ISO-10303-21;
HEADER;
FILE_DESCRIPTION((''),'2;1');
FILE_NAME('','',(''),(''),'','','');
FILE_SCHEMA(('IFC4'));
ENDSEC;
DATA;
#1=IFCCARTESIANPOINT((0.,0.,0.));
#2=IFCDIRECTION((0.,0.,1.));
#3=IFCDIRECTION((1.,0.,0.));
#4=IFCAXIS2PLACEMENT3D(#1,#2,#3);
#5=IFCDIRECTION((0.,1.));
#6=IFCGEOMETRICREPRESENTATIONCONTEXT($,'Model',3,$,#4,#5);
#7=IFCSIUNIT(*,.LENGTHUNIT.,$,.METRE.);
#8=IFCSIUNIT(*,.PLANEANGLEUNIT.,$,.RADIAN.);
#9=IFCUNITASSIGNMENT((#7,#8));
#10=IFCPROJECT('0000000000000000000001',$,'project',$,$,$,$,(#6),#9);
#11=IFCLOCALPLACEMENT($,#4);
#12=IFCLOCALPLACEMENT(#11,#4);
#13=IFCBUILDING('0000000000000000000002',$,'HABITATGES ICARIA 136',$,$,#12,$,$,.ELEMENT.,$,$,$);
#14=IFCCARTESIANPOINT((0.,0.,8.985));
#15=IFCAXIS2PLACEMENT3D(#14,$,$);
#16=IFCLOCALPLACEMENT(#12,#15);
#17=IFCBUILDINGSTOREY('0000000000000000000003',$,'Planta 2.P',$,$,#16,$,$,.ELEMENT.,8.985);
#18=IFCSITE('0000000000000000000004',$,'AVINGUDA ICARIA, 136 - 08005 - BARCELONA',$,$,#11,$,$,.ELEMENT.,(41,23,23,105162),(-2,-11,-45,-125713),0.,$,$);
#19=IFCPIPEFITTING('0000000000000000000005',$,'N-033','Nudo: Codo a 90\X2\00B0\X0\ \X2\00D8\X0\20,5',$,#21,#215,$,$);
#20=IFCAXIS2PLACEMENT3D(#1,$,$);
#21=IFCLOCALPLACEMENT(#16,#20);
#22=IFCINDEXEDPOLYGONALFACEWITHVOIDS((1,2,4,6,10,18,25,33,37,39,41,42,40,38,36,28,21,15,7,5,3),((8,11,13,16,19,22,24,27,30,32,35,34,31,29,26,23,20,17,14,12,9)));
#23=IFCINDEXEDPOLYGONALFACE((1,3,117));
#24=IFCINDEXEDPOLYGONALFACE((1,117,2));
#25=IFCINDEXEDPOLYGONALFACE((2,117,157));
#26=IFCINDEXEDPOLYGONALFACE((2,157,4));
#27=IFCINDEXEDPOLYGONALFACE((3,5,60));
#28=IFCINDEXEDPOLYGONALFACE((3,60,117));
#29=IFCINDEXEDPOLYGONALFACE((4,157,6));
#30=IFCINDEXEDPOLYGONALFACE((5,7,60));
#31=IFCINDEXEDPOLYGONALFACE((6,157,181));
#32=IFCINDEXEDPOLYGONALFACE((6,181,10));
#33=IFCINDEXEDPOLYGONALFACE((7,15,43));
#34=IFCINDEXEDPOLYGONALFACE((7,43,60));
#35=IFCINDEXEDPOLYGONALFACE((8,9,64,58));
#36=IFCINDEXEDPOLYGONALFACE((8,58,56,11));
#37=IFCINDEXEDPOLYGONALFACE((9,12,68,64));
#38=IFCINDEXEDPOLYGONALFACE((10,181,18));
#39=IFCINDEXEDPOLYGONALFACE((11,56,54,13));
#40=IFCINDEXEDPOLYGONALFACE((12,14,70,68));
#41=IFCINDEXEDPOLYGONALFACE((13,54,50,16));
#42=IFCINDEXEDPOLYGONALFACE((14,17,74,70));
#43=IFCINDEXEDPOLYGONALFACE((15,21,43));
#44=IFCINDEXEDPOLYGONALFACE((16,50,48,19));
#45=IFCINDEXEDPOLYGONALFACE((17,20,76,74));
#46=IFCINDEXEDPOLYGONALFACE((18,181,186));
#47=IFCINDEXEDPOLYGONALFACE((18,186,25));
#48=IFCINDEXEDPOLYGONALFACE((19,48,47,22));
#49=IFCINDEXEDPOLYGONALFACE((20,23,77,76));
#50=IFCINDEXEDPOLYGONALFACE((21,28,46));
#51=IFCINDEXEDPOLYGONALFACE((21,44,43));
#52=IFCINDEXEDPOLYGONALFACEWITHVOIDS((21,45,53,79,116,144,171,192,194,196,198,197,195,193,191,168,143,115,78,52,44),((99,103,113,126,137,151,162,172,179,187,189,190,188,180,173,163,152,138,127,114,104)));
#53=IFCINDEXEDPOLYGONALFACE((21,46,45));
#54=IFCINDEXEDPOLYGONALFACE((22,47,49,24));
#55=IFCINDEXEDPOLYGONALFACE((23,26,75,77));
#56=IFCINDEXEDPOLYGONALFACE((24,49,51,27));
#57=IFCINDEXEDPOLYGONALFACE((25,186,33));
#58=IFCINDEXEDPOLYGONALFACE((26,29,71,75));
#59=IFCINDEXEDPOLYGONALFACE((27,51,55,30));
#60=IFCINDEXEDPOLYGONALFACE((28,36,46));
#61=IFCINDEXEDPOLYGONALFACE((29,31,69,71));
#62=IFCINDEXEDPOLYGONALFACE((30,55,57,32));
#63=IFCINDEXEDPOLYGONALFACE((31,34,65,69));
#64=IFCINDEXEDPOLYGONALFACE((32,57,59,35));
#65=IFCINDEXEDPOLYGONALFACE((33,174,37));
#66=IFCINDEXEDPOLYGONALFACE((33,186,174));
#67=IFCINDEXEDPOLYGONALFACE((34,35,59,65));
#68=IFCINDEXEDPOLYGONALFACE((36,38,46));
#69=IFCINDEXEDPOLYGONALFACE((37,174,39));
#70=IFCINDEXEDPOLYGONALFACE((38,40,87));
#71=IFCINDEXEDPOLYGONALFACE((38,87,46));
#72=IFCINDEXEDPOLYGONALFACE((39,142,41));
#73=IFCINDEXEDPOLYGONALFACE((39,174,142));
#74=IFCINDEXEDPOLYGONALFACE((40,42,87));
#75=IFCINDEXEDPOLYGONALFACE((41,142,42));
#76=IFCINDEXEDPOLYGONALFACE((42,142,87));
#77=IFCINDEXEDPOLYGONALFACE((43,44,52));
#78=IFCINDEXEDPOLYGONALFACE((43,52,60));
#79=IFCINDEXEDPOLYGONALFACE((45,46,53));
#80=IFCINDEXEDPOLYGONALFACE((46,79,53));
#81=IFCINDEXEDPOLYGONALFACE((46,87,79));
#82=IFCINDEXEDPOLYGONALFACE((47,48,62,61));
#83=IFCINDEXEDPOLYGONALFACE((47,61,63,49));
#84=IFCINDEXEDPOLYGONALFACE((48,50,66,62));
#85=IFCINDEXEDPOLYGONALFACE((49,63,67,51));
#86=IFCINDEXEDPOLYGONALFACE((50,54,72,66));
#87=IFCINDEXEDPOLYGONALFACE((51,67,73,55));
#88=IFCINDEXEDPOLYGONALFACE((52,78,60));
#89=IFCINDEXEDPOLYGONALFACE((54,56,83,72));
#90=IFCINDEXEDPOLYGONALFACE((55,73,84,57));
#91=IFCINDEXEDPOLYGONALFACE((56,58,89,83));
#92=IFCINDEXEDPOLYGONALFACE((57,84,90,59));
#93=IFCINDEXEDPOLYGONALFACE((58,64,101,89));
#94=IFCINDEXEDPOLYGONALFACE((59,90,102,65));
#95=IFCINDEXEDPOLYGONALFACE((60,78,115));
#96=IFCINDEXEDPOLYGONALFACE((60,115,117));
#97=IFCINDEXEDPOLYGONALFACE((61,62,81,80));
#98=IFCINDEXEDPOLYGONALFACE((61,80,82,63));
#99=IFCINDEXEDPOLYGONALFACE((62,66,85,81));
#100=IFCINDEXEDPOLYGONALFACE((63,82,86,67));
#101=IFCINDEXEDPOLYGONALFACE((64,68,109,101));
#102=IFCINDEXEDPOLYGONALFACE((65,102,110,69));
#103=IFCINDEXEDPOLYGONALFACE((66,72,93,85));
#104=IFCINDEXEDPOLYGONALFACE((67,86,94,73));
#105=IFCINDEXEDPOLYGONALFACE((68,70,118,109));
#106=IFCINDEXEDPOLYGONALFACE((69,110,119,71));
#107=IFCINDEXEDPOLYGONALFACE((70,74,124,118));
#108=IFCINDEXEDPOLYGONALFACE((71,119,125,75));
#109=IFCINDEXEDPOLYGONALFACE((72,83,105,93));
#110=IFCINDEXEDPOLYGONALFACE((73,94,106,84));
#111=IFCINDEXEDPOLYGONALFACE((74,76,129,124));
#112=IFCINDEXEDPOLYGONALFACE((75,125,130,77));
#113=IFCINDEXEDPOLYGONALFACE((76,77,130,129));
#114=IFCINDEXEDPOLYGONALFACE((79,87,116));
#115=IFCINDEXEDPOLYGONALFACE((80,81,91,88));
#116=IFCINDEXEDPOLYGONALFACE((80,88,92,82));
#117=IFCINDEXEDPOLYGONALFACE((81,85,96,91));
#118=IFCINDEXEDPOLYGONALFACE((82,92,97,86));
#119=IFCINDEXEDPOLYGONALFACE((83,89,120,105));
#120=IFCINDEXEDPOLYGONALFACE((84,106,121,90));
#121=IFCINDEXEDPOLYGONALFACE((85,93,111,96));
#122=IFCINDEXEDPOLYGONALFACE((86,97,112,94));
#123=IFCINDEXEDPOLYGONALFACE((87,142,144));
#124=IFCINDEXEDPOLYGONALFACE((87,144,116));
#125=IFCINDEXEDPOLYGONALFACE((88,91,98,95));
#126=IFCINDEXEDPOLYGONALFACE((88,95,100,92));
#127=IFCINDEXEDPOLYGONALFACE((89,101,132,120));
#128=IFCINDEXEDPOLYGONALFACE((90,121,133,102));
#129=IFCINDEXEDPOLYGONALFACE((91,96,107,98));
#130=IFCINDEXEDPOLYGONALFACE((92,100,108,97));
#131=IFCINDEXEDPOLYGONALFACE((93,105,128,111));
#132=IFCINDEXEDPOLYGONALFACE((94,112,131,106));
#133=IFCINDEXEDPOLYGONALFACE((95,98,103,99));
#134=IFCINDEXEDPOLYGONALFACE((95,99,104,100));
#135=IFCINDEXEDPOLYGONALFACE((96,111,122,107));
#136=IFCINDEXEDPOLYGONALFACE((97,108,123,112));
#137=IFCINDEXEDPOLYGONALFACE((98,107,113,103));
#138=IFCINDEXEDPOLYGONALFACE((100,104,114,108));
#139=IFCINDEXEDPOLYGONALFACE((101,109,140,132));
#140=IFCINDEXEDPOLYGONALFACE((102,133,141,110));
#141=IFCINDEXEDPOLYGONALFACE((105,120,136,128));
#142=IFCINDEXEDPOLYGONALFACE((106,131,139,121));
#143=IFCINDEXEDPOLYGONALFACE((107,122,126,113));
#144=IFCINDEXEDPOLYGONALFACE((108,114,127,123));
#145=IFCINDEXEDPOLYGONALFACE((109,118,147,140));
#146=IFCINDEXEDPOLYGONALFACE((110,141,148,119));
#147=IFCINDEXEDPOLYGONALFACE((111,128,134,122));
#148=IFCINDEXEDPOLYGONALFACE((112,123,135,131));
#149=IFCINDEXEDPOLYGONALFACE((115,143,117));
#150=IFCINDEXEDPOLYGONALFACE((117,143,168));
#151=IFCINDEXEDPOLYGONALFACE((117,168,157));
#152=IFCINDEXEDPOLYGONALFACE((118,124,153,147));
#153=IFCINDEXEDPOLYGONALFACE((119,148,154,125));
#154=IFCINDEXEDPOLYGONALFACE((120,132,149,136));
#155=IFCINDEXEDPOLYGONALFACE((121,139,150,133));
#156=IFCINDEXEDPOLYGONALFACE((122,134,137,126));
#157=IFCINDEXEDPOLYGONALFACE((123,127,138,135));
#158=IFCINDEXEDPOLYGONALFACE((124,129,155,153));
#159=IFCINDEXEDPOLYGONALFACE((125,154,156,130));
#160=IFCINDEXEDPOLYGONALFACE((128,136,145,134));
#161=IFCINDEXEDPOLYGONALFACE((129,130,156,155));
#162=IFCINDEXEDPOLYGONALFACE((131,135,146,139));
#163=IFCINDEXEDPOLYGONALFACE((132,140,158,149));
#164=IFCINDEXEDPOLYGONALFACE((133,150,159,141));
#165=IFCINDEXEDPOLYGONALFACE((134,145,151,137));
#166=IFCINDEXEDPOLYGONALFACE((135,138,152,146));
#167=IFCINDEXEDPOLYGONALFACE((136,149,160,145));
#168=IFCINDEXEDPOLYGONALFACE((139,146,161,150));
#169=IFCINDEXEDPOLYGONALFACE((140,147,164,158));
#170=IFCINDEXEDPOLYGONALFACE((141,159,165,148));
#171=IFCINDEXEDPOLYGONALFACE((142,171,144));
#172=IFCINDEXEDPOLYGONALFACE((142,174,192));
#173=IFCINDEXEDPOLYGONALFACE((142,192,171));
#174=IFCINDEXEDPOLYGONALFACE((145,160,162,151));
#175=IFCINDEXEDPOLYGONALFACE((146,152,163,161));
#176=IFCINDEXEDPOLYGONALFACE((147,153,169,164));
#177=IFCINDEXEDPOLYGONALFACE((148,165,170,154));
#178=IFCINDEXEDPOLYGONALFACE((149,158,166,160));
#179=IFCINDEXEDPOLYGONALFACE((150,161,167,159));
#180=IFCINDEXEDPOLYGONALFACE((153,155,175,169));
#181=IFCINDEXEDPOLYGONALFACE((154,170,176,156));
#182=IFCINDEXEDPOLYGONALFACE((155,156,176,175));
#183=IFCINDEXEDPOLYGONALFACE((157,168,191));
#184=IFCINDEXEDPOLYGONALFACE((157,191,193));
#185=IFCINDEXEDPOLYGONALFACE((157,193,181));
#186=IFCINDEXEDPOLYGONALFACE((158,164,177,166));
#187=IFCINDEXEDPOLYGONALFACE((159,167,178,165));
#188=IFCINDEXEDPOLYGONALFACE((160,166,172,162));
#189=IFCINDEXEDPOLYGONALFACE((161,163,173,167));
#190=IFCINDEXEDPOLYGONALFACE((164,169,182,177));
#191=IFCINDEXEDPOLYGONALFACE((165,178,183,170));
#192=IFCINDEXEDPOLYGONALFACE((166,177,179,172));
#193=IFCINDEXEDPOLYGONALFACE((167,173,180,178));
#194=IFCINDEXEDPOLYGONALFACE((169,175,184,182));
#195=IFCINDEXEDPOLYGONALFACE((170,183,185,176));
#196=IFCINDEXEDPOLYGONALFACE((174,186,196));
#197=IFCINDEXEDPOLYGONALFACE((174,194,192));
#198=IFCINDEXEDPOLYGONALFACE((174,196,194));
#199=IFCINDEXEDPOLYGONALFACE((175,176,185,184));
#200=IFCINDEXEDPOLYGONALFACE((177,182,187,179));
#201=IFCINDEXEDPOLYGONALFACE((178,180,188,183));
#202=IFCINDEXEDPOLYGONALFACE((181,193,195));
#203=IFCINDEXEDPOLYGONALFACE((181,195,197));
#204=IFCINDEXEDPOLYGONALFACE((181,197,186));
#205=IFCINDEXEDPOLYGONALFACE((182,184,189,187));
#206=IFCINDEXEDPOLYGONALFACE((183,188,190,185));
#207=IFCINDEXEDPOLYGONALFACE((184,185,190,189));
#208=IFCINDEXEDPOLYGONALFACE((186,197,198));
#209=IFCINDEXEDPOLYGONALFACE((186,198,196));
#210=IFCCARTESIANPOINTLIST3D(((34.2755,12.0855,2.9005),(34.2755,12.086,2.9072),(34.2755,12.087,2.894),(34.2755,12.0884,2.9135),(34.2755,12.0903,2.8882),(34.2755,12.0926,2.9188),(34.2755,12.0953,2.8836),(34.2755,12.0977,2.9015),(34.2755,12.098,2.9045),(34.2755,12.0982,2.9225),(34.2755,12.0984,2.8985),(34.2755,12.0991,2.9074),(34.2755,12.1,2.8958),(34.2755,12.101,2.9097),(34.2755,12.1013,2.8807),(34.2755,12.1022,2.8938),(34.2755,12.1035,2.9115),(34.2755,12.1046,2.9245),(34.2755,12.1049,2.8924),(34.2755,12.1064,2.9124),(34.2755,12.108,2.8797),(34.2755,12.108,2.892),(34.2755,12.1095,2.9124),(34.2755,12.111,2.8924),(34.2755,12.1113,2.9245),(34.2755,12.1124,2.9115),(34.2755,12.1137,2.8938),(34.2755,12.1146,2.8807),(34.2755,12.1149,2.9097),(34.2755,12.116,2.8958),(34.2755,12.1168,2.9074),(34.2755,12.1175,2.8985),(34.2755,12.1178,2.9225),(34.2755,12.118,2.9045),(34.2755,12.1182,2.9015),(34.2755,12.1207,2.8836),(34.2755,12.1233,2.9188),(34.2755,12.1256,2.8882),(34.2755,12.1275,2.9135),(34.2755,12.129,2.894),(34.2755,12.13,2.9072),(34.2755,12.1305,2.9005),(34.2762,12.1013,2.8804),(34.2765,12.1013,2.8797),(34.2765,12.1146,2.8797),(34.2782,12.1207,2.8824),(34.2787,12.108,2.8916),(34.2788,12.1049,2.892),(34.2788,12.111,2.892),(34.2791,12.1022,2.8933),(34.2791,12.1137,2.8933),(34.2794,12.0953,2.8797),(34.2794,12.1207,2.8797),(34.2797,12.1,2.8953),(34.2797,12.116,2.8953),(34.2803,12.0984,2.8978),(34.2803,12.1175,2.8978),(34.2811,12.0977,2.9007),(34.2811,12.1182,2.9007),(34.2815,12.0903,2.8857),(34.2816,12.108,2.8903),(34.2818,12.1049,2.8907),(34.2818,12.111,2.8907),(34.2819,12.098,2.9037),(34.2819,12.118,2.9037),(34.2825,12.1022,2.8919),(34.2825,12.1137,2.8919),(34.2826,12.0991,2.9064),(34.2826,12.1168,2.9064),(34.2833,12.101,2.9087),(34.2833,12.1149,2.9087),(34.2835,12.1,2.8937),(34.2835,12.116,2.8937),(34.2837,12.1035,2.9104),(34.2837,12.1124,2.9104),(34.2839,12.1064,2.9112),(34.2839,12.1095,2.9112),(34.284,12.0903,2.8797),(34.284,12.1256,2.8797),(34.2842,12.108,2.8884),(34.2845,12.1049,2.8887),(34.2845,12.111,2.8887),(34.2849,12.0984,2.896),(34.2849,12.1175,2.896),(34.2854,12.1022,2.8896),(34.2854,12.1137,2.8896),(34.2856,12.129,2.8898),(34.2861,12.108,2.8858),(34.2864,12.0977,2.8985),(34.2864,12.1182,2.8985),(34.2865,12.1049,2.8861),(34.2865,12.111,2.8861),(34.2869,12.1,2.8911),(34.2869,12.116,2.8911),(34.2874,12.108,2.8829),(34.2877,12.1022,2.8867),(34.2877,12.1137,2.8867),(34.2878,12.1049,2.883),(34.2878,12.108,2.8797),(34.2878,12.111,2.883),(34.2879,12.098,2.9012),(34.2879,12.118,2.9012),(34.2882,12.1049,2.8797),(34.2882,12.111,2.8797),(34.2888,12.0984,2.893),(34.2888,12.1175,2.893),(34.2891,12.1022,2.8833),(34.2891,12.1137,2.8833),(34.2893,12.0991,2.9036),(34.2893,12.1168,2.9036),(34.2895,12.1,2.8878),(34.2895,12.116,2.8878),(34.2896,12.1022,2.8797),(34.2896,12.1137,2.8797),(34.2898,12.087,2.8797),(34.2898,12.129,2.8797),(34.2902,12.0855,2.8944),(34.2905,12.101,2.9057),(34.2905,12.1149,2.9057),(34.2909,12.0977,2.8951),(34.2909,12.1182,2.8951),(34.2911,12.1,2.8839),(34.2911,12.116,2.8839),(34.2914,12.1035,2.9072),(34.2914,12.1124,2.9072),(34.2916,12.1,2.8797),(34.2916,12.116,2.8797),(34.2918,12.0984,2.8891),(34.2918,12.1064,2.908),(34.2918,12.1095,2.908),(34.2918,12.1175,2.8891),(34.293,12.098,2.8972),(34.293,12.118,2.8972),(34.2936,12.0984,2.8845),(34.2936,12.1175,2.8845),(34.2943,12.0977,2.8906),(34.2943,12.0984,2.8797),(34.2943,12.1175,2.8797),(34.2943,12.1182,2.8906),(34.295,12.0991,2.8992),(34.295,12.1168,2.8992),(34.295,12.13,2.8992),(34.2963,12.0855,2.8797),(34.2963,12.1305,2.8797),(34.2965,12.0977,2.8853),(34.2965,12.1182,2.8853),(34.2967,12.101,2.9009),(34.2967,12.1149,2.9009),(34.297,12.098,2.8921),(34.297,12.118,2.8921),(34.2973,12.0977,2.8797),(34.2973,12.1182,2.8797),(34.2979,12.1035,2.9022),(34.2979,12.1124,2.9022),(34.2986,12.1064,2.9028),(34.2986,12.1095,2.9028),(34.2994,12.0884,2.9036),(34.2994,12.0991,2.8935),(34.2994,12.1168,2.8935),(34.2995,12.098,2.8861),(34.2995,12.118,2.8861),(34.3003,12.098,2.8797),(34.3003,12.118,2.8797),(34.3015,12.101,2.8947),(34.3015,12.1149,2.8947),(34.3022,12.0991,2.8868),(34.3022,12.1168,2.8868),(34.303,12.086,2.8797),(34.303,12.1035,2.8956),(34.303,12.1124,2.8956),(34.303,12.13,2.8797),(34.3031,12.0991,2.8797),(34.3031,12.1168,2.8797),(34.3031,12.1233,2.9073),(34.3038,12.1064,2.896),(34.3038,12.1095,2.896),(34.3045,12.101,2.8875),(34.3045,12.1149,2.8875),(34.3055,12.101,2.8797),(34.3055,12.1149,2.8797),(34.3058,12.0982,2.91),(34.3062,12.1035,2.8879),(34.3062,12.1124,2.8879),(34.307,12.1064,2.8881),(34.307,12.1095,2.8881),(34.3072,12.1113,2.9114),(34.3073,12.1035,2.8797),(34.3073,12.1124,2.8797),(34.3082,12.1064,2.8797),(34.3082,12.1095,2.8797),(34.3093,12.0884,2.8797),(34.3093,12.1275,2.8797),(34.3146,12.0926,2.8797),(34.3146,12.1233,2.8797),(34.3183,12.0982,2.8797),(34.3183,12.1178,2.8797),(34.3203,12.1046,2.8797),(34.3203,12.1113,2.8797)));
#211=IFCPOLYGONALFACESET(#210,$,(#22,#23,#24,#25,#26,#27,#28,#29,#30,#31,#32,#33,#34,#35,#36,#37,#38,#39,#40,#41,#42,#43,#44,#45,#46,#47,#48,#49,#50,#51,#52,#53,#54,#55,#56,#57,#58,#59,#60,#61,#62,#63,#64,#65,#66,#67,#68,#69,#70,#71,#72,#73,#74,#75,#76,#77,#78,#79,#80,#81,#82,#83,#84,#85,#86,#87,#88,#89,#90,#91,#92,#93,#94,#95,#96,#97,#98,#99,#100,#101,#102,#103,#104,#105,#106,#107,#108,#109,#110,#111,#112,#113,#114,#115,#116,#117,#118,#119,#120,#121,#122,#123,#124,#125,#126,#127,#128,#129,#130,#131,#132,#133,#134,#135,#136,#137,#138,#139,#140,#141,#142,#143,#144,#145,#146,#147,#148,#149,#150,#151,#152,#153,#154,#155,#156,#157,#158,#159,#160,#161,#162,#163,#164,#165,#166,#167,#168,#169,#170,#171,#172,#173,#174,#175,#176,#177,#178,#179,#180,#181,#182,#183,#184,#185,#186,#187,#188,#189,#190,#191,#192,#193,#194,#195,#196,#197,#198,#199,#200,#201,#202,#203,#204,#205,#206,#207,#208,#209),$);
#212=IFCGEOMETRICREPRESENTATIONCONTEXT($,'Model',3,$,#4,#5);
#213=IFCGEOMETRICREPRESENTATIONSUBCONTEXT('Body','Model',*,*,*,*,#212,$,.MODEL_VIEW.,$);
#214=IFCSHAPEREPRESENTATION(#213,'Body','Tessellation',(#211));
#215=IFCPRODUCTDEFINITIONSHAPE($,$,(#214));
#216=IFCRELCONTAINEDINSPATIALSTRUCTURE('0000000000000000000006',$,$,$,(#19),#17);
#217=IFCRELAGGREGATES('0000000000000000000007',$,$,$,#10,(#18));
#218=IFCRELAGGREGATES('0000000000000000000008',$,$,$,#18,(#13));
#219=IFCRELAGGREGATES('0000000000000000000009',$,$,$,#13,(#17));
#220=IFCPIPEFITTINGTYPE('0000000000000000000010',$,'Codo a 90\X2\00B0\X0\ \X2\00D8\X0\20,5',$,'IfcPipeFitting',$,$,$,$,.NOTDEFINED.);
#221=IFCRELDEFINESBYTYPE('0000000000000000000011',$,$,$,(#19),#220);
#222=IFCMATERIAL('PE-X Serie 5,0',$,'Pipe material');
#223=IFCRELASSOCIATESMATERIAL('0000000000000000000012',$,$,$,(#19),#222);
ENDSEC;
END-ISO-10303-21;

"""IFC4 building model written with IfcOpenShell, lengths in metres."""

from ifc_helpers import new_model, entity, si_unit, direction, frame, origin_with_axes, place, context, subcontext, project, spatial, source, transform, mapped, material, type_object, element, save


model = new_model("IFC4")

# Units and contexts
model_context_1 = context("Model", 3, world=origin_with_axes(), true_north=direction((0.0, 1.0)))
model_context_2 = context("Model", 3, world=origin_with_axes(), true_north=direction((0.0, 1.0)))
body_context_1 = subcontext(model_context_2, "Body", "Model", "MODEL_VIEW")
ifc_project = project(units=[si_unit("LENGTHUNIT", "METRE"), si_unit("PLANEANGLEUNIT", "RADIAN")], contexts=[model_context_1])

# Site, building, storey
site_placement = place(None, origin_with_axes())
site = spatial("IfcSite", under=ifc_project, at=site_placement, Name="AVINGUDA ICARIA, 136 - 08005 - BARCELONA", CompositionType="ELEMENT", RefLatitude=(41, 23, 23, 105162), RefLongitude=(-2, -11, -45, -125713), RefElevation=0.0)
building_placement = place(site_placement, origin_with_axes())
building = spatial("IfcBuilding", under=site, at=building_placement, Name="HABITATGES ICARIA 136", CompositionType="ELEMENT")
storey_placement = place(building_placement, frame((0.0, 0.0, 8.985)))
storey = spatial("IfcBuildingStorey", under=building, at=storey_placement, Name="Planta 2.P", CompositionType="ELEMENT", Elevation=8.985)

# Shared definitions
ifc_material_1 = material(Name="PE-X Serie 5,0", Category="Pipe material")
placement_1 = place(None, origin_with_axes())
placement_2 = place(placement_1, origin_with_axes())
placement_3 = place(placement_2, frame((0.0, 0.0, 8.985)))

# Pipe fitting
pipe_fitting_type_1 = type_object("IfcPipeFittingType", Name="Codo a 90° Ø20,5", ApplicableOccurrence="IfcPipeFitting", PredefinedType="NOTDEFINED")
shared_shape_1 = source(origin_with_axes(), body_context_1, "Body", "SweptSolid", [
    entity("IfcRevolvedAreaSolid", entity("IfcCircleHollowProfileDef", "AREA", None, entity("IfcAxis2Placement2D", entity("IfcCartesianPoint", [0.0, 0.0]), entity("IfcDirection", [1.0, 0.0])), 0.0226, 0.0123), entity("IfcAxis2Placement3D", entity("IfcCartesianPoint", [0.0226, 0.0, 0.0]), entity("IfcDirection", [-1.0, 0.0, 0.0]), entity("IfcDirection", [0.0, -1.0, 0.0])), entity("IfcAxis1Placement", entity("IfcCartesianPoint", [0.0226, 0.0, 0.0]), entity("IfcDirection", [0.0, 1.0, 0.0])), 1.570796),
])
pipe_fitting_1_placement = place(placement_3, origin_with_axes())
element("IfcPipeFitting", 1, at=pipe_fitting_1_placement, inside=storey, type_object=pipe_fitting_type_1, material=ifc_material_1, Name="N-033", Description="Nudo: Codo a 90° Ø20,5", context=body_context_1, shape_type="MappedRepresentation", body=[
    mapped(shared_shape_1, transform((34.298, 12.108, 2.9022), x_axis=(-1.0, 0.0, 0.0), y_axis=(0.0, 0.0, 1.0), z_axis=(0.0, 1.0, 0.0), scale=1.0)),
])

save(model, "model.ifc")
